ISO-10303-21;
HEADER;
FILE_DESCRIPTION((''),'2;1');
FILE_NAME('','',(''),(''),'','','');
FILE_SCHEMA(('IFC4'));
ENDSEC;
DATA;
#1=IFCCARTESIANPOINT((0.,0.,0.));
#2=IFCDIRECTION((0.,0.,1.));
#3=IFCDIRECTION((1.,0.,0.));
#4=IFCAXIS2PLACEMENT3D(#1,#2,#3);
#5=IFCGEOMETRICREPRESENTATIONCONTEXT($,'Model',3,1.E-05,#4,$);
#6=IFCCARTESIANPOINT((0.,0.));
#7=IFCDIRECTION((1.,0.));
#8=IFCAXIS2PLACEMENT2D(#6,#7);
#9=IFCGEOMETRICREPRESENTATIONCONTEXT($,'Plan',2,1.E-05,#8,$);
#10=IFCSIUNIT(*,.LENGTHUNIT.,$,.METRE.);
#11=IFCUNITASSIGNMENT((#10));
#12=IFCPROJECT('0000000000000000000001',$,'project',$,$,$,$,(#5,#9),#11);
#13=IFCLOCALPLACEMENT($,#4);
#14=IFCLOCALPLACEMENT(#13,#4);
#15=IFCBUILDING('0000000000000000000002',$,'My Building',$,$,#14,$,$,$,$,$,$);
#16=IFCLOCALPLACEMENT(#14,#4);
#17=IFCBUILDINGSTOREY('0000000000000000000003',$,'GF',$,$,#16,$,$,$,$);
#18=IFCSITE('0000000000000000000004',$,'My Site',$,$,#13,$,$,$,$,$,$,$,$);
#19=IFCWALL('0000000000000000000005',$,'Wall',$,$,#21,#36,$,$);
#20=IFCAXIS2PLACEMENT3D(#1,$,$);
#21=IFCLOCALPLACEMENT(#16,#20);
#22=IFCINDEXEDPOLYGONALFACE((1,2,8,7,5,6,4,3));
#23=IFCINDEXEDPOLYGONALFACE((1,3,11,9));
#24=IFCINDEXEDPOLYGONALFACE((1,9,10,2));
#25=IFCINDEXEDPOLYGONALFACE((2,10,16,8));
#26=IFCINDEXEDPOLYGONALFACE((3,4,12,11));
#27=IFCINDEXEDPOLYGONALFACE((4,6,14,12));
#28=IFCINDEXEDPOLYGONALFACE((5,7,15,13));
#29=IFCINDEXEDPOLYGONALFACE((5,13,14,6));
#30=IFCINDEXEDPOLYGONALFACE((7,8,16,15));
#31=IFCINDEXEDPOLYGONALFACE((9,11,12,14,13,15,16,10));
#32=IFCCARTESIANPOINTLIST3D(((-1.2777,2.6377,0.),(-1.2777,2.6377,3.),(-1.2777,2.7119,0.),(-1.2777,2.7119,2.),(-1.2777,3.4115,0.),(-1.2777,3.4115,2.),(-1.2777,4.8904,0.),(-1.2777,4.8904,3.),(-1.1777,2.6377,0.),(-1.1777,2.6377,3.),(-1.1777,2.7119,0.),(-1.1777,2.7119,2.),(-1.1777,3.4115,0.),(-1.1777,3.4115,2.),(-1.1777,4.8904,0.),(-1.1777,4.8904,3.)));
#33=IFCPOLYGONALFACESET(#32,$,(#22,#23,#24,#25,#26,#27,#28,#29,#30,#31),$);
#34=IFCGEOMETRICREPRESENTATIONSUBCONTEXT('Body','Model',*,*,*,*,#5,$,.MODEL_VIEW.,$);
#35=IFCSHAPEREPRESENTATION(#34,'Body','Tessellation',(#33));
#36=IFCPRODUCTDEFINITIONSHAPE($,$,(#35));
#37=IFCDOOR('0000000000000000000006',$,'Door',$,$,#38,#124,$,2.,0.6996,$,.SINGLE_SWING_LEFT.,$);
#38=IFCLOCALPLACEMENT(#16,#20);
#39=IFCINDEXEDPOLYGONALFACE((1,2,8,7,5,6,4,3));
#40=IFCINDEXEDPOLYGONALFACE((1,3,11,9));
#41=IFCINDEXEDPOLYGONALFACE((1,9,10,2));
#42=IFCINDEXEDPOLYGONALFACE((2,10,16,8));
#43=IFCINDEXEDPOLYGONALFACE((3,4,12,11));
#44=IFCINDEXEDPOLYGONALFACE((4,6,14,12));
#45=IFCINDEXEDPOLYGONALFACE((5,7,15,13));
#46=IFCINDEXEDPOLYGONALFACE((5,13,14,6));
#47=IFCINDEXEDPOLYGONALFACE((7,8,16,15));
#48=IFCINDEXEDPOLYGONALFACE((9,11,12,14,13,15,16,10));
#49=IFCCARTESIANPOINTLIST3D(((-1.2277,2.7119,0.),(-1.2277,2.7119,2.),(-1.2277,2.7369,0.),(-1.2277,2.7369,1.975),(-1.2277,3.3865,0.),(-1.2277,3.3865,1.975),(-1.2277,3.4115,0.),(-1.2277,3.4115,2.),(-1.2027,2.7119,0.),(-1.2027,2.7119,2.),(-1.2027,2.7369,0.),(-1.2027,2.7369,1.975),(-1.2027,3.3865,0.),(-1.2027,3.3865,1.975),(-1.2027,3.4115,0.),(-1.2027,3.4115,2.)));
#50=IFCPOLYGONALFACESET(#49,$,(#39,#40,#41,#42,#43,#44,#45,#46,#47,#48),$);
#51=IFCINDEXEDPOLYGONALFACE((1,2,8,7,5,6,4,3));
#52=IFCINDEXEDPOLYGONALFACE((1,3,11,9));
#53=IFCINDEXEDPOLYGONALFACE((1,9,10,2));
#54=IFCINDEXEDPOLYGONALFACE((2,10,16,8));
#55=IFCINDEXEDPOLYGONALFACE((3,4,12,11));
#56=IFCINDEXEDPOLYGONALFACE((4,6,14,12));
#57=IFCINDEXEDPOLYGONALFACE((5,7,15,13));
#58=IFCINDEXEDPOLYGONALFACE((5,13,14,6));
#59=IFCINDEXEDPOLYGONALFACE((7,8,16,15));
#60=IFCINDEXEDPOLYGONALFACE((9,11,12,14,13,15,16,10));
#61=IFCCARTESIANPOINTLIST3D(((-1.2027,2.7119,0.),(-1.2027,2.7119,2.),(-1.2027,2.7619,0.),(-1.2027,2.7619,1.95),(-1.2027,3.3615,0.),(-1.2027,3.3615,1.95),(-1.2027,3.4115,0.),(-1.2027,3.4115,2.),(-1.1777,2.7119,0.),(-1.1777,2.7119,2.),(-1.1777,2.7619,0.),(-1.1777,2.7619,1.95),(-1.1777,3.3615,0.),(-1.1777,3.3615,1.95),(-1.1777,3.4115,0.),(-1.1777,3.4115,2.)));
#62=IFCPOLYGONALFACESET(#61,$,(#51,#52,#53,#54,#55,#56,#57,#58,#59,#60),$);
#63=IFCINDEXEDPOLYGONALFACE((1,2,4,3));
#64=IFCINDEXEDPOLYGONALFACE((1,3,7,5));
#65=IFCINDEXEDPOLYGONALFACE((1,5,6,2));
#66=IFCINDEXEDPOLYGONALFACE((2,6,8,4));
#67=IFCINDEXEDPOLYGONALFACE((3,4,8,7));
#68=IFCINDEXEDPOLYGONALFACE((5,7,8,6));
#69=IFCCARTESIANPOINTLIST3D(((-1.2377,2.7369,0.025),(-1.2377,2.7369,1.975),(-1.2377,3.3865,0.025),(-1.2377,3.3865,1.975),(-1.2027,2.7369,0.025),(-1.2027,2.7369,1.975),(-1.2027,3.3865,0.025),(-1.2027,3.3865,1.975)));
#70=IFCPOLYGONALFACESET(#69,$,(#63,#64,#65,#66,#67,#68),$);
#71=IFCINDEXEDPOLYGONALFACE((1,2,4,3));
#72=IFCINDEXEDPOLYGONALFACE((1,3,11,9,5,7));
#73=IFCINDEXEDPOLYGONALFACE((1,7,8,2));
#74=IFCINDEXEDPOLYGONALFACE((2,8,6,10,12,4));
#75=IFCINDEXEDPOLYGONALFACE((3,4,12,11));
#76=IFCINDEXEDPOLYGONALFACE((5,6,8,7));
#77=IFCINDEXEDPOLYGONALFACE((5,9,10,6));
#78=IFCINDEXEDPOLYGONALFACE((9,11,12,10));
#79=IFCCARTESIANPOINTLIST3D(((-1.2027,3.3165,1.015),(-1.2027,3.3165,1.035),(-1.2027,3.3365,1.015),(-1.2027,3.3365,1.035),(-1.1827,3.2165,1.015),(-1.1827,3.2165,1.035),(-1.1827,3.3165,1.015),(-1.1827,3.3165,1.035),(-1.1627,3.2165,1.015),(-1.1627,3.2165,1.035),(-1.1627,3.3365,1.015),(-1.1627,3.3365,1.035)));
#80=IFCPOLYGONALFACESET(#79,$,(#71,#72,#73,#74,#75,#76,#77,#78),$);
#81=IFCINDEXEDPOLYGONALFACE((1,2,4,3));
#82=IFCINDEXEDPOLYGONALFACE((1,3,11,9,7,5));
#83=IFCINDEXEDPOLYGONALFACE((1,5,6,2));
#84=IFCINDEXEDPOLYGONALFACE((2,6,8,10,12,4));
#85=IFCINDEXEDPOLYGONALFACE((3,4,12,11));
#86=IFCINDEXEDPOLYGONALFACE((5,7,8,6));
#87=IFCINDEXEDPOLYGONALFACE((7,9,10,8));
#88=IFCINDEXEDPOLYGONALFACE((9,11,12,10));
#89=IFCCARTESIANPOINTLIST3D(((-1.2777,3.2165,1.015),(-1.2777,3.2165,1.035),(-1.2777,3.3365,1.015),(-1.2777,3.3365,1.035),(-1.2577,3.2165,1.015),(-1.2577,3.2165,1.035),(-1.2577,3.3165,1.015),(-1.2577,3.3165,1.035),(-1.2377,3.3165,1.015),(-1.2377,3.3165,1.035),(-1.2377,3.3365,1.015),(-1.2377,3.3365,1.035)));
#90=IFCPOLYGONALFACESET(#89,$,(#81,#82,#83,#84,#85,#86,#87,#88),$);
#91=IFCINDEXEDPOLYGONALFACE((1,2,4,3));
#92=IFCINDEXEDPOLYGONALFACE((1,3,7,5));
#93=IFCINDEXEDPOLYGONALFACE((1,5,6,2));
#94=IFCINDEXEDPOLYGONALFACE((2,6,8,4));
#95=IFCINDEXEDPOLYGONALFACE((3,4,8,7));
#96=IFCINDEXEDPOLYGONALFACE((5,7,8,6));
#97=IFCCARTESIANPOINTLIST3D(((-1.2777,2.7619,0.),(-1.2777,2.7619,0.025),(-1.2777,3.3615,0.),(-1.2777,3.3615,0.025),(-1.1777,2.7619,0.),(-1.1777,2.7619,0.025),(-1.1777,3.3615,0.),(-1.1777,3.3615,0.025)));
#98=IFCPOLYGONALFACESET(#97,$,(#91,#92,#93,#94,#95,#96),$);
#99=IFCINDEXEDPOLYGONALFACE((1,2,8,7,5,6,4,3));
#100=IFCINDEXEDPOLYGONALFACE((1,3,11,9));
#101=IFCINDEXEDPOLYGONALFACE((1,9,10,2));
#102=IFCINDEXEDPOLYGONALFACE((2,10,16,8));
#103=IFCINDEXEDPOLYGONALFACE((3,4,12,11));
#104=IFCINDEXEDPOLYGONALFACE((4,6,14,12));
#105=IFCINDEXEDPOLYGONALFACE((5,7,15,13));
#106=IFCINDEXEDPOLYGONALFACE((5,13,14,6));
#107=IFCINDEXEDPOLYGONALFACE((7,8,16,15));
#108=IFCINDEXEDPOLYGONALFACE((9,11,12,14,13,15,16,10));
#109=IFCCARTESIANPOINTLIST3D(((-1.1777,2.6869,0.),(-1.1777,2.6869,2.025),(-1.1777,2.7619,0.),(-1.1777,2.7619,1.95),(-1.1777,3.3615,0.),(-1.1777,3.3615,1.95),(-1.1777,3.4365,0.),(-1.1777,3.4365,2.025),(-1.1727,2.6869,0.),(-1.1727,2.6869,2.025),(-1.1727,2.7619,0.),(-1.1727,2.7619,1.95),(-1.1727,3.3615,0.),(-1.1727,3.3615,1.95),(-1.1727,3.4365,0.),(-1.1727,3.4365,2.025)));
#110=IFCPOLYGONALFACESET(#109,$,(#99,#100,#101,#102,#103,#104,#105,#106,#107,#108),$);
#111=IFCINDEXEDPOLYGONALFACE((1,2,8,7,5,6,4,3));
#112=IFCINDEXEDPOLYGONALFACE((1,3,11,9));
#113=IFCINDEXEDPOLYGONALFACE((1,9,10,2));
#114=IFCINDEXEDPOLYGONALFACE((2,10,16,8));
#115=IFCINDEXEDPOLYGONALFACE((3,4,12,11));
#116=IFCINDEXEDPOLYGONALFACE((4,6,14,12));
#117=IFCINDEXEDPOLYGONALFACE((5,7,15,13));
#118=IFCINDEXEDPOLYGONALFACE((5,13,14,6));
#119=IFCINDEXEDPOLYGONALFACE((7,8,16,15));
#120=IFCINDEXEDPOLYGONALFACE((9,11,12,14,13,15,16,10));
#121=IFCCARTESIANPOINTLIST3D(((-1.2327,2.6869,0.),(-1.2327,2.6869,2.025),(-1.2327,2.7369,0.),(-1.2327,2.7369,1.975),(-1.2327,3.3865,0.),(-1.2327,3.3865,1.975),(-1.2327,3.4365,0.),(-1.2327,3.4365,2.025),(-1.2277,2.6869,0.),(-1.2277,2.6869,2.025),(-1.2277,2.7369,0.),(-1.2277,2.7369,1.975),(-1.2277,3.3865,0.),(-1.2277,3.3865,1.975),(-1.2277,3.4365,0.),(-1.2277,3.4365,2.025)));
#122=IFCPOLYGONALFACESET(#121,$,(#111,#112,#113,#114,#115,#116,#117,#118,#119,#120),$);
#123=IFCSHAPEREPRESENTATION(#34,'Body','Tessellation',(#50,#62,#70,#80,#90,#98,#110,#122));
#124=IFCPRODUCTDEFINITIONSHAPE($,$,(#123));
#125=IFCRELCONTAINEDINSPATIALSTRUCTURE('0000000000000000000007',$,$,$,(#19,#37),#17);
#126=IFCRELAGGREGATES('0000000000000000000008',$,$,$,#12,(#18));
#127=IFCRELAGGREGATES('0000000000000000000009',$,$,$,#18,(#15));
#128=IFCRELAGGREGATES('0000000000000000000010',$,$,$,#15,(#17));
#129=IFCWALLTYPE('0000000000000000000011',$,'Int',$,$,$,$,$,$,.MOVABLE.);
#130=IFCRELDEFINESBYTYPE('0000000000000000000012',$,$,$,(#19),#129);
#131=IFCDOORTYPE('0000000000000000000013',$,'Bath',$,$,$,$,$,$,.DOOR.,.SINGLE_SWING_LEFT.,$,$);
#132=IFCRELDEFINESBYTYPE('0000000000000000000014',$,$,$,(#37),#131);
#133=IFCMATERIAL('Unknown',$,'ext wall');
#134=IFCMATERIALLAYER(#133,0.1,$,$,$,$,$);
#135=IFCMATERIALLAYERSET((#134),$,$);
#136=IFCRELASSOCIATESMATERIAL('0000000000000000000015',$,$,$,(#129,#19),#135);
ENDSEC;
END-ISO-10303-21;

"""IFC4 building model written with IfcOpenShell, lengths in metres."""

from ifc_helpers import new_model, entity, si_unit, frame, origin_with_axes, origin_2d_with_axis, place, context, subcontext, project, spatial, line, indexed_curve, outline, extrude, shape, source, transform, mapped, material, layer, layer_set, layer_usage, type_object, type_shapes, element, fill, save


model = new_model("IFC4")

# Units and contexts
model_context = context("Model", 3, precision=1e-05, world=origin_with_axes())
plan_context = context("Plan", 2, precision=1e-05, world=origin_2d_with_axis())
body_context_1 = subcontext(model_context, "Body", "Model", "MODEL_VIEW")
body_context_2 = subcontext(plan_context, "Body", "Plan", "PLAN_VIEW")
ifc_project = project(units=[si_unit("LENGTHUNIT", "METRE")], contexts=[model_context, plan_context])

# Site, building, storey
site_placement = place(None, origin_with_axes())
site = spatial("IfcSite", under=ifc_project, at=site_placement, Name="My Site")
building_placement = place(site_placement, origin_with_axes())
building = spatial("IfcBuilding", under=site, at=building_placement, Name="My Building")
storey_placement = place(building_placement, origin_with_axes())
storey = spatial("IfcBuildingStorey", under=building, at=storey_placement, Name="GF")

# Shared definitions
ifc_material = material(Name="Unknown", Category="ext wall")

# Shared definitions
ifc_layer_1 = layer(ifc_material, 0.1)
ifc_layer_set_1 = layer_set([ifc_layer_1])
wall_type_1 = type_object("IfcWallType", Name="Int", PredefinedType="MOVABLE", material=ifc_layer_set_1)

# Wall, opening, door
ifc_layer_usage_1 = layer_usage(ifc_layer_set_1, "AXIS2", "POSITIVE", 0.0)
wall_1_placement = place(storey_placement, frame((-1.2777, 4.8904, 0.0), z_axis=(0.0, 0.0, 1.0), x_axis=(0.0, -1.0, 0.0)))
wall_1 = element("IfcWall", 1, at=wall_1_placement, inside=storey, type_object=wall_type_1, material=ifc_layer_usage_1, Name="Wall", context=body_context_1, shape_type="SweptSolid", body=[
    extrude(outline(indexed_curve([(0.0, 0.0), (0.0, 0.1), (2.2527, 0.1), (2.2527, 0.0)], segments=[line(1, 2, 3, 4, 1)])), origin_with_axes(), (0.0, 0.0, 1.0), 3.0),
])
shared_shape_1 = source(origin_with_axes(), body_context_1, "Body", "SweptSolid", [
    extrude(outline(indexed_curve([(0.0, 0.0), (0.6996, 0.0), (0.6996, 2.0), (0.0, 2.0)], segments=[line(1, 2, 3, 4, 1)])), frame((0.0, -0.6, 0.0), z_axis=(0.0, -1.0, 0.0), x_axis=(1.0, 0.0, 0.0)), (0.0, 0.0, -1.0), 1.2),
])
opening_1_placement = place(wall_1_placement, frame((2.1785, 0.1, 0.0), z_axis=(0.0, 0.0, 1.0), x_axis=(-1.0, 0.0, 0.0)))
opening_1 = element("IfcOpeningElement", 2, at=opening_1_placement, cuts=wall_1, PredefinedType="OPENING", context=body_context_1, shape_type="MappedRepresentation", body=[
    mapped(shared_shape_1, transform((0.0, 0.0, 0.0), x_axis=(1.0, 0.0, 0.0), y_axis=(0.0, 1.0, 0.0), z_axis=(0.0, 0.0, 1.0), scale=1.0)),
])
door_type_1 = type_object("IfcDoorType", Name="Bath", OperationType="SINGLE_SWING_LEFT", PredefinedType="DOOR")
shared_shape_2 = source(origin_with_axes(), body_context_1, "Body", "SweptSolid", [
    extrude(outline(indexed_curve([(0.0, 0.0), (0.0, 2.0), (0.6996, 2.0), (0.6996, 0.0), (0.6746, 0.0), (0.6746, 1.975), (0.025, 1.975), (0.025, 0.0)], segments=[line(1, 2, 3, 4, 5, 6, 7, 8, 1)])), frame((0.0, 0.025, 0.0), z_axis=(0.0, -1.0, 0.0), x_axis=(1.0, 0.0, 0.0)), (0.0, 0.0, -1.0), 0.025),
    extrude(outline(indexed_curve([(0.0, 0.0), (0.0, 2.0), (0.6996, 2.0), (0.6996, 0.0), (0.6496, 0.0), (0.6496, 1.95), (0.05, 1.95), (0.05, 0.0)], segments=[line(1, 2, 3, 4, 5, 6, 7, 8, 1)])), frame((0.0, 0.0, 0.0), z_axis=(0.0, -1.0, 0.0), x_axis=(1.0, 0.0, 0.0)), (0.0, 0.0, -1.0), 0.025),
    extrude(outline(indexed_curve([(0.0, 0.0), (0.6496, 0.0), (0.6496, 0.035), (0.0, 0.035)], segments=[line(1, 2, 3, 4, 1)])), frame((0.025, 0.025, 0.025), z_axis=(0.0, 0.0, 1.0), x_axis=(1.0, 0.0, 0.0)), (0.0, 0.0, 1.0), 1.95),
    extrude(outline(indexed_curve([(0.0, 0.0), (0.0, -0.04), (-0.12, -0.04), (-0.12, -0.02), (-0.02, -0.02), (-0.02, 0.0)], segments=[line(1, 2, 3, 4, 5, 6, 1)])), frame((0.6246, 0.025, 1.015), z_axis=(0.0, 0.0, 1.0), x_axis=(1.0, 0.0, 0.0)), (0.0, 0.0, 1.0), 0.02),
    extrude(outline(indexed_curve([(0.0, 0.0), (0.0, 0.04), (-0.12, 0.04), (-0.12, 0.02), (-0.02, 0.02), (-0.02, 0.0)], segments=[line(1, 2, 3, 4, 5, 6, 1)])), frame((0.6246, 0.06, 1.015), z_axis=(0.0, 0.0, 1.0), x_axis=(1.0, 0.0, 0.0)), (0.0, 0.0, 1.0), 0.02),
    extrude(outline(indexed_curve([(0.0, 0.0), (0.5996, 0.0), (0.5996, 0.1), (0.0, 0.1)], segments=[line(1, 2, 3, 4, 1)])), frame((0.05, 0.0, 0.0), z_axis=(0.0, 0.0, 1.0), x_axis=(1.0, 0.0, 0.0)), (0.0, 0.0, 1.0), 0.025),
    extrude(outline(indexed_curve([(0.0, 0.0), (0.0, 2.025), (0.7496, 2.025), (0.7496, 0.0), (0.6746, 0.0), (0.6746, 1.95), (0.075, 1.95), (0.075, 0.0)], segments=[line(1, 2, 3, 4, 5, 6, 7, 8, 1)])), frame((-0.025, -0.005, 0.0), z_axis=(0.0, -1.0, 0.0), x_axis=(1.0, 0.0, 0.0)), (0.0, 0.0, -1.0), 0.005),
    extrude(outline(indexed_curve([(0.0, 0.0), (0.0, 2.025), (0.7496, 2.025), (0.7496, 0.0), (0.6996, 0.0), (0.6996, 1.975), (0.05, 1.975), (0.05, 0.0)], segments=[line(1, 2, 3, 4, 5, 6, 7, 8, 1)])), frame((-0.025, 0.05, 0.0), z_axis=(0.0, -1.0, 0.0), x_axis=(1.0, 0.0, 0.0)), (0.0, 0.0, -1.0), 0.005),
])
shared_shape_3 = source(origin_with_axes(), body_context_2, "Body", "Curve2D", [
    entity("IfcIndexedPolyCurve", entity("IfcCartesianPointList2D", [[0.0, 0.0], [0.0, 0.05], [0.025, 0.05], [0.025, 0.025], [0.05, 0.025], [0.05, 0.0]]), [entity("IfcLineIndex", [1, 2, 3, 4, 5, 6, 1])]),
    entity("IfcIndexedPolyCurve", entity("IfcCartesianPointList2D", [[0.6996, 0.0], [0.6996, 0.05], [0.6746, 0.05], [0.6746, 0.025], [0.6496, 0.025], [0.6496, 0.0]]), [entity("IfcLineIndex", [1, 2, 3, 4, 5, 6, 1])]),
    entity("IfcTrimmedCurve", entity("IfcEllipse", entity("IfcAxis2Placement2D", entity("IfcCartesianPoint", [0.06, 0.05]), entity("IfcDirection", [1.0, 0.0])), 0.6146, 0.6496), [entity("IfcCartesianPoint", [0.6746, 0.05])], [entity("IfcCartesianPoint", [0.06, 0.6996])], True, "CARTESIAN"),
    entity("IfcIndexedPolyCurve", entity("IfcCartesianPointList2D", [[0.025, 0.05], [0.06, 0.05], [0.06, 0.6996], [0.025, 0.6996]]), [entity("IfcLineIndex", [1, 2, 3, 4, 1])]),
])
type_shapes(door_type_1, [shared_shape_2, shared_shape_3])
door_1_placement = place(opening_1_placement, frame((0.0, 0.0, 0.0), z_axis=(0.0, 0.0, 1.0), x_axis=(1.0, 0.0, 0.0)))
door_1 = element("IfcDoor", 3, at=door_1_placement, inside=storey, type_object=door_type_1, Name="Door", OperationType="SINGLE_SWING_LEFT", OverallHeight=2.0, OverallWidth=0.6996, shapes=[
    shape(body_context_1, "Body", "MappedRepresentation", [mapped(shared_shape_2, transform((0.0, 0.0, 0.0), x_axis=(1.0, 0.0, 0.0), y_axis=(0.0, 1.0, 0.0), z_axis=(0.0, 0.0, 1.0), scale=1.0))]),
    shape(body_context_2, "Body", "MappedRepresentation", [mapped(shared_shape_3, transform((0.0, 0.0, 0.0), x_axis=(1.0, 0.0, 0.0), y_axis=(0.0, 1.0, 0.0), z_axis=(0.0, 0.0, 1.0), scale=1.0))]),
])
fill(opening_1, door_1)

save(model, "model.ifc")
